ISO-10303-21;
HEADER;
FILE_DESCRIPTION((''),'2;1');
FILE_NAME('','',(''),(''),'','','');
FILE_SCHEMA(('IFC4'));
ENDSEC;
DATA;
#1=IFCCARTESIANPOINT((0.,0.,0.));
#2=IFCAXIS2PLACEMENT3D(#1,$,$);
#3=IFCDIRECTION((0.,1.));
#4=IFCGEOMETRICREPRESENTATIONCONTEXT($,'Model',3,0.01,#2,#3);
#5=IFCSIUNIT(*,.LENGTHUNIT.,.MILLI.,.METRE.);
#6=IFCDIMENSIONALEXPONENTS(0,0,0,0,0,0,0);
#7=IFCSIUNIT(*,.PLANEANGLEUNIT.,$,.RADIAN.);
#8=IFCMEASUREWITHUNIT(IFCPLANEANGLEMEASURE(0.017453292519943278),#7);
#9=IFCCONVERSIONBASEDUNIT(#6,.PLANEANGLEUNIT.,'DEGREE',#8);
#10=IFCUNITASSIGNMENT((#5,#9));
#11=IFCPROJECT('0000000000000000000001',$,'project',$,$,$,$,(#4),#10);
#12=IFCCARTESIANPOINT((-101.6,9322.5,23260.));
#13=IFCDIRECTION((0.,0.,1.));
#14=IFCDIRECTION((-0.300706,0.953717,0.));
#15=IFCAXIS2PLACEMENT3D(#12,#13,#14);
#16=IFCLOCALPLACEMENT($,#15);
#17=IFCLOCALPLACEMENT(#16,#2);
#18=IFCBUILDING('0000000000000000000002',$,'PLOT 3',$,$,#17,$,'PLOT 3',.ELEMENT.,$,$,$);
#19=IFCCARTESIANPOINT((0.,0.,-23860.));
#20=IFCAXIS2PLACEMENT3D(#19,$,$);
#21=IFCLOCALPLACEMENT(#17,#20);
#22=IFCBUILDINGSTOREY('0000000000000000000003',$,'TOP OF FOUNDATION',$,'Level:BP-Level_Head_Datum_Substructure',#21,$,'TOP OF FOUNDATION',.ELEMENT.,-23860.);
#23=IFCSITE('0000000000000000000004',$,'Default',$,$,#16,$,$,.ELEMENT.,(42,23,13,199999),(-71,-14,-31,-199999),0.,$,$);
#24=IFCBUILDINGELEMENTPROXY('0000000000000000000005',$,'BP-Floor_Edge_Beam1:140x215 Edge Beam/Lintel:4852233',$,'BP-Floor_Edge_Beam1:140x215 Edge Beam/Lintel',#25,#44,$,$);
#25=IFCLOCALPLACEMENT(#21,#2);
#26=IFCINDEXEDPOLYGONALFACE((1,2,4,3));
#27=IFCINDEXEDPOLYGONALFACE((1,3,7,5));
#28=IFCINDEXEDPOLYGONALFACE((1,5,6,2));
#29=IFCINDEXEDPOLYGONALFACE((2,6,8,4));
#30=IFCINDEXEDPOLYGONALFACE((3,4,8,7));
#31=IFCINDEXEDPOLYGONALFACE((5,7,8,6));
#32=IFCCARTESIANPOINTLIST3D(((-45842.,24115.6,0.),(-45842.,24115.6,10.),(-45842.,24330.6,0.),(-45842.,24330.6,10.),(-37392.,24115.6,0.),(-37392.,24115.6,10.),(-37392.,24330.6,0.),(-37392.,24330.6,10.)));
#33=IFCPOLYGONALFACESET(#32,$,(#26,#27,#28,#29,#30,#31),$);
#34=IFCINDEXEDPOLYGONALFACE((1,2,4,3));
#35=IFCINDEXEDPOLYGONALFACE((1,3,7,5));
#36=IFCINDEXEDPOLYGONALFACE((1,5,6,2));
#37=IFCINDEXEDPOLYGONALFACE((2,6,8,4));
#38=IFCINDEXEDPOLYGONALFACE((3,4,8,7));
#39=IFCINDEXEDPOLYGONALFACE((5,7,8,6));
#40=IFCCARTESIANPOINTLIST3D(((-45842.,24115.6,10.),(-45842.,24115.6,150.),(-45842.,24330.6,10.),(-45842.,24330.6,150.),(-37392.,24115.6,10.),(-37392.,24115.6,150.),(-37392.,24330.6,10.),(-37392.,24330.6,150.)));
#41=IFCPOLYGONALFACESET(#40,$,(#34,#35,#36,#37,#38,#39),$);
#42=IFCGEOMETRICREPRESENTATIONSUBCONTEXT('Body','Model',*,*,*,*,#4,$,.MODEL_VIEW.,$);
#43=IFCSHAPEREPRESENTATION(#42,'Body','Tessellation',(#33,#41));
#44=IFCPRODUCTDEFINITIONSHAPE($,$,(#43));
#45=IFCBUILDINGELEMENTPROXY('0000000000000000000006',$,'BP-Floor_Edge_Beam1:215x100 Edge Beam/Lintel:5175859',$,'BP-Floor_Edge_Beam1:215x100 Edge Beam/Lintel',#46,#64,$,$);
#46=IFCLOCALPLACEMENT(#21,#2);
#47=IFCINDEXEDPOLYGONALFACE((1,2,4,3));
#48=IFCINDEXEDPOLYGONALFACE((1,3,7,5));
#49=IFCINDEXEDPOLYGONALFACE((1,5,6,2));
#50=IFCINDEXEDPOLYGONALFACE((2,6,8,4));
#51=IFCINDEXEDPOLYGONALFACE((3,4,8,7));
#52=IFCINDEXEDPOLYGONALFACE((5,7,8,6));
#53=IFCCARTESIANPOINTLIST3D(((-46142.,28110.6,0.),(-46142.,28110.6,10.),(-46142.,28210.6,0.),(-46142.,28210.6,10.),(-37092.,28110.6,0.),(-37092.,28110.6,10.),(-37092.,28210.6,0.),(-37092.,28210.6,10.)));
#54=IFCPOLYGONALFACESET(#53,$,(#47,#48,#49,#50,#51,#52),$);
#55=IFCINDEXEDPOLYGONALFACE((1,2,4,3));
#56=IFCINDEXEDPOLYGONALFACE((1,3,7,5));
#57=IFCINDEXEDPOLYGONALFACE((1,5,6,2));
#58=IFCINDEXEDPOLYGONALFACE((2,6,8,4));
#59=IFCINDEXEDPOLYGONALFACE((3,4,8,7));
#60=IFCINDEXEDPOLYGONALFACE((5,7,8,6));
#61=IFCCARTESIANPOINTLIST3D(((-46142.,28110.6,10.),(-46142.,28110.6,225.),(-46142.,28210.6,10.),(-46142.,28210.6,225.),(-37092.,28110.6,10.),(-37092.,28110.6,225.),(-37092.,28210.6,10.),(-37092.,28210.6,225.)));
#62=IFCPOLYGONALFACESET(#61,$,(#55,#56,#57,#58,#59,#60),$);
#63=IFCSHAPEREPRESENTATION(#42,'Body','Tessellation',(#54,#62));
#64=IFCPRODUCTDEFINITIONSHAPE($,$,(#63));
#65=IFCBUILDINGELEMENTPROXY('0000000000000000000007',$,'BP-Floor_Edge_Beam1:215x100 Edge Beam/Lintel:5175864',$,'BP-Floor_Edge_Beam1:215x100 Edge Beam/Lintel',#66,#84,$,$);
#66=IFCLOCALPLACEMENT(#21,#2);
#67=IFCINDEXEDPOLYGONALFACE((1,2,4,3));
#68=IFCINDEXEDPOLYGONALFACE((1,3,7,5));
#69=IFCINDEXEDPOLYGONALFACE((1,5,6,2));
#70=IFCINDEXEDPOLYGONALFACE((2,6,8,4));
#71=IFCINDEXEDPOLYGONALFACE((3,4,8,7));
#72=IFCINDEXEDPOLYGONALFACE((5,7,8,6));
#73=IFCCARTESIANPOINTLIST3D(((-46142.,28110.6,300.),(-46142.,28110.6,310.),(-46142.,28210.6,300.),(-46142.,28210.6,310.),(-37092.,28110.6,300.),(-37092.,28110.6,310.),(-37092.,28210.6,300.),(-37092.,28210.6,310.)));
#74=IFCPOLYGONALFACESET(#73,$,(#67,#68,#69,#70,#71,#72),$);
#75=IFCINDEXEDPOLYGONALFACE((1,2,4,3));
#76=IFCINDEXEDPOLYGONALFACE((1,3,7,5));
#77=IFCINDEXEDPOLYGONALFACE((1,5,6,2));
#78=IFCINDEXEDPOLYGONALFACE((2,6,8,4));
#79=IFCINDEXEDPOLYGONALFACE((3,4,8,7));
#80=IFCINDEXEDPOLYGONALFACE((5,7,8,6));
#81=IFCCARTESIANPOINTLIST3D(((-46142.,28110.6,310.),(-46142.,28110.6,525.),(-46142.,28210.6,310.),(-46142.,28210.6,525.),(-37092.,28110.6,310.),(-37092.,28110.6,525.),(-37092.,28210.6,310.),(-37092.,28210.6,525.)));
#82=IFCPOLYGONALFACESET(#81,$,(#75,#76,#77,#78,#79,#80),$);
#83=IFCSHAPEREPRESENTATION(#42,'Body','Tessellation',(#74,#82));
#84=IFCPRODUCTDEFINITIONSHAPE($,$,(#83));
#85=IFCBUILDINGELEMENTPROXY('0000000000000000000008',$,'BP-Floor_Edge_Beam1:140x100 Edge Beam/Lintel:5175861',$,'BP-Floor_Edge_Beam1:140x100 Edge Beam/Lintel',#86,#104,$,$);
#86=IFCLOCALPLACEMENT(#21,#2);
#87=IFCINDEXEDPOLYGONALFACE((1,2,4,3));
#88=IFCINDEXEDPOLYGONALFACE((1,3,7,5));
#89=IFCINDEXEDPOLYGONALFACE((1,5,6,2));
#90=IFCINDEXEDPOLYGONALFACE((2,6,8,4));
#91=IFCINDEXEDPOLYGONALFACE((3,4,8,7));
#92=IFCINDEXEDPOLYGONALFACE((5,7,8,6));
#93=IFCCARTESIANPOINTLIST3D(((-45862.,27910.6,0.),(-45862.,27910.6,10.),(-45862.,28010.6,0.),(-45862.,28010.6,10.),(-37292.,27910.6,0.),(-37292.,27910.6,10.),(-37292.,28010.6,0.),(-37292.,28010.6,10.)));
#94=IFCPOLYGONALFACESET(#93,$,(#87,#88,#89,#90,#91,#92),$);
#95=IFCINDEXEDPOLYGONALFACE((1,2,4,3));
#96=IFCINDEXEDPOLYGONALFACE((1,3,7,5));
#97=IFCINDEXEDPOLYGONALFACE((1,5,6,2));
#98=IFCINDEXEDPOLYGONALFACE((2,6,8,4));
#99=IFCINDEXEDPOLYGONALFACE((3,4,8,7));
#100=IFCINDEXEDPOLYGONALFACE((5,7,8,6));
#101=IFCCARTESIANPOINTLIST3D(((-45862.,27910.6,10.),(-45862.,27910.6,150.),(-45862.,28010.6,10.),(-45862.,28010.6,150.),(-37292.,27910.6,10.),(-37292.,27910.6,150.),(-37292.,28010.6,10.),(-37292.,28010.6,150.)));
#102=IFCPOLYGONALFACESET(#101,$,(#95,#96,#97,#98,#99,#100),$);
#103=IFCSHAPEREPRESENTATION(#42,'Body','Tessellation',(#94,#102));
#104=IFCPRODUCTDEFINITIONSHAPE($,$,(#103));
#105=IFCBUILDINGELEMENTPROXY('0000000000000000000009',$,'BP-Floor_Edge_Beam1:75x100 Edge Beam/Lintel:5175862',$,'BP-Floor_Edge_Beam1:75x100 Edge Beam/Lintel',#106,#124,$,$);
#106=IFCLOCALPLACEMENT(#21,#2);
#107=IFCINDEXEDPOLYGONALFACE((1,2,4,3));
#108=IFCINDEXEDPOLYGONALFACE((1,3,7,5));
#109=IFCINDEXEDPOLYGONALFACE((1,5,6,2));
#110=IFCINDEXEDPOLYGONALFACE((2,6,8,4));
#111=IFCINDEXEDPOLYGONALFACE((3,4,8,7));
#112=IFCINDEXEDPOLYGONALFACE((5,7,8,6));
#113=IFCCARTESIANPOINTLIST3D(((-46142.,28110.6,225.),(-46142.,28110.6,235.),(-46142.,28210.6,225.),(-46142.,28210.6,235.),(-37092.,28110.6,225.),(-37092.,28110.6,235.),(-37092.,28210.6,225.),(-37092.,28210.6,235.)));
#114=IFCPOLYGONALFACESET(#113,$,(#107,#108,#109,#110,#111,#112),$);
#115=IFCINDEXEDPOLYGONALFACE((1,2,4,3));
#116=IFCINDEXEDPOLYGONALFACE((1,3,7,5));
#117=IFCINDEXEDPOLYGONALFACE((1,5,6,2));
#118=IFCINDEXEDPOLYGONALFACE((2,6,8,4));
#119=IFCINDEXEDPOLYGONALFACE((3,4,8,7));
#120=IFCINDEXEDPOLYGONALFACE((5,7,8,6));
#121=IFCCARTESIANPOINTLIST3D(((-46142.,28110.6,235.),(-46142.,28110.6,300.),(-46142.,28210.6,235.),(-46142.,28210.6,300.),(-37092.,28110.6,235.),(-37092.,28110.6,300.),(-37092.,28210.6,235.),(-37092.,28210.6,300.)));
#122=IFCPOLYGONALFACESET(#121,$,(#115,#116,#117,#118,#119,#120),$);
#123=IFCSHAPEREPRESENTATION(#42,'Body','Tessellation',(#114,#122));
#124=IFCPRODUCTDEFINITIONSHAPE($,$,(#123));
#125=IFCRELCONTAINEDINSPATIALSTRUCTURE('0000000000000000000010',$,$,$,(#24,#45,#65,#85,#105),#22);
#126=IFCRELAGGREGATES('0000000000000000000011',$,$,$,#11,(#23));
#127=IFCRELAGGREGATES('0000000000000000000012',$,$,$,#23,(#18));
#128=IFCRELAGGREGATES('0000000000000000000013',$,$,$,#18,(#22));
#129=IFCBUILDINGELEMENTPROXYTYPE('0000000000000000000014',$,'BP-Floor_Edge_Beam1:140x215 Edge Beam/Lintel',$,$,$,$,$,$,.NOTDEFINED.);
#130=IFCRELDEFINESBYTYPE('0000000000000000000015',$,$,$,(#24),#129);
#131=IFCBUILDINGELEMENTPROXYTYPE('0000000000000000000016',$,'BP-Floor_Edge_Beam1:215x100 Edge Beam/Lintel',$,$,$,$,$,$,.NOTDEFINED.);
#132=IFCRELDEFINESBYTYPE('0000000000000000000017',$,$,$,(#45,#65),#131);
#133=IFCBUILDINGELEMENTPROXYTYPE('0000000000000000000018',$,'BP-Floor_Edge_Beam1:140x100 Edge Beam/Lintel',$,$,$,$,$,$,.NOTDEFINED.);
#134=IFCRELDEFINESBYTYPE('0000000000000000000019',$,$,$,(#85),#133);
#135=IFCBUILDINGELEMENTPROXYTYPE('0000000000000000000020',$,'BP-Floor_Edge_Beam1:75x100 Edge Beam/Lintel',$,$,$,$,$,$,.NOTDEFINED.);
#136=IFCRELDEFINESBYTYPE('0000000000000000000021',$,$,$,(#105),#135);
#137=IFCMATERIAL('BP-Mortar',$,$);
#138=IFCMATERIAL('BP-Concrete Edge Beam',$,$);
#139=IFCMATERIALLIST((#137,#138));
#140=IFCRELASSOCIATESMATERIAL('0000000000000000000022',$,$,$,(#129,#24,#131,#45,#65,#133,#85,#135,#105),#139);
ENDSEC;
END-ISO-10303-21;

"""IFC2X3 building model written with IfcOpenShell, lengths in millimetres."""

from ifc_helpers import new_model, entity, si_unit, converted_unit, direction, frame, frame_2d, origin, origin_2d_with_axis, place, context, subcontext, project, spatial, rectangle, extrude, source, transform, mapped, material, material_list, type_object, type_shapes, element, save


model = new_model("IFC2X3")

# Units and contexts
model_context = context("Model", 3, precision=0.01, world=origin(), true_north=direction((0.0, 1.0)))
body_context = subcontext(model_context, "Body", "Model", "MODEL_VIEW")
ifc_project = project(units=[si_unit("LENGTHUNIT", "METRE", prefix="MILLI"), converted_unit("PLANEANGLEUNIT", "DEGREE", entity("IfcPlaneAngleMeasure", 0.017453292519943278), si_unit("PLANEANGLEUNIT", "RADIAN"), dimensions=[0, 0, 0, 0, 0, 0, 0])], contexts=[model_context])

# Site, building, storey
site_placement = place(None, frame((-101.6, 9322.5, 23260.0), z_axis=(0.0, 0.0, 1.0), x_axis=(-0.300706, 0.953717, 0.0)))
site = spatial("IfcSite", under=ifc_project, at=site_placement, Name="Default", CompositionType="ELEMENT", RefLatitude=(42, 23, 13, 199999), RefLongitude=(-71, -14, -31, -199999), RefElevation=0.0)
building_placement = place(site_placement, origin())
building = spatial("IfcBuilding", under=site, at=building_placement, Name="PLOT 3", LongName="PLOT 3", CompositionType="ELEMENT")
storey_placement = place(building_placement, frame((0.0, 0.0, -23860.0)))
storey = spatial("IfcBuildingStorey", under=building, at=storey_placement, Name="TOP OF FOUNDATION", ObjectType="Level:BP-Level_Head_Datum_Substructure", LongName="TOP OF FOUNDATION", CompositionType="ELEMENT", Elevation=-23860.0)

# Building element proxies
ifc_material_1 = material(Name="BP-Mortar")
ifc_material_2 = material(Name="BP-Concrete Edge Beam")
ifc_material_list = material_list([ifc_material_1, ifc_material_2])
building_element_proxy_type_1 = type_object("IfcBuildingElementProxyType", Name="BP-Floor_Edge_Beam1:140x215 Edge Beam/Lintel", PredefinedType="NOTDEFINED", material=ifc_material_list)
shared_shape_1 = source(origin(), body_context, "Body", "SweptSolid", [
    extrude(rectangle(XDim=215.0, YDim=8450.0, at=origin_2d_with_axis()), frame((0.0, 0.0, 0.0), z_axis=(0.0, 0.0, 1.0), x_axis=(0.0, 1.0, 0.0)), (0.0, 0.0, 1.0), 10.0),
    extrude(rectangle(XDim=215.0, YDim=8450.0, at=origin_2d_with_axis()), frame((0.0, 0.0, 10.0), z_axis=(0.0, 0.0, 1.0), x_axis=(0.0, 1.0, 0.0)), (0.0, 0.0, 1.0), 140.0),
])
type_shapes(building_element_proxy_type_1, [shared_shape_1])
proxy_1_placement = place(storey_placement, frame((-41617.0, 24223.1, 0.0), z_axis=(0.0, 0.0, 1.0), x_axis=(-1.0, 0.0, 0.0)))
element("IfcBuildingElementProxy", 1, at=proxy_1_placement, inside=storey, type_object=building_element_proxy_type_1, material=ifc_material_list, Name="BP-Floor_Edge_Beam1:140x215 Edge Beam/Lintel:4852233", ObjectType="BP-Floor_Edge_Beam1:140x215 Edge Beam/Lintel", context=body_context, shape_type="MappedRepresentation", body=[
    mapped(shared_shape_1, transform((0.0, 0.0, 0.0), scale=1.0)),
])
building_element_proxy_type_2 = type_object("IfcBuildingElementProxyType", Name="BP-Floor_Edge_Beam1:215x100 Edge Beam/Lintel", PredefinedType="NOTDEFINED", material=ifc_material_list)
shared_shape_2 = source(origin(), body_context, "Body", "SweptSolid", [
    extrude(rectangle(XDim=100.0, YDim=9050.0, at=frame_2d((0.0, 0.0), x_axis=(1.0, 0.0))), frame((0.0, 0.0, 0.0), z_axis=(0.0, 0.0, 1.0), x_axis=(0.0, 1.0, 0.0)), (0.0, 0.0, 1.0), 10.0),
    extrude(rectangle(XDim=100.0, YDim=9050.0, at=origin_2d_with_axis()), frame((0.0, 0.0, 10.0), z_axis=(0.0, 0.0, 1.0), x_axis=(0.0, 1.0, 0.0)), (0.0, 0.0, 1.0), 215.0),
])
type_shapes(building_element_proxy_type_2, [shared_shape_2])
for number, where, z_axis, x_axis, name in (
    (2, (-41617.0, 28160.6, 0.0), (0.0, 0.0, 1.0), (-1.0, 0.0, 0.0), "BP-Floor_Edge_Beam1:215x100 Edge Beam/Lintel:5175859"),
    (3, (-41617.0, 28160.6, 300.0), (0.0, 0.0, 1.0), (-1.0, 0.0, 0.0), "BP-Floor_Edge_Beam1:215x100 Edge Beam/Lintel:5175864"),
):
    element("IfcBuildingElementProxy", number, at=place(storey_placement, frame(where, z_axis=z_axis, x_axis=x_axis)), inside=storey, type_object=building_element_proxy_type_2, material=ifc_material_list, Name=name, ObjectType="BP-Floor_Edge_Beam1:215x100 Edge Beam/Lintel", context=body_context, shape_type="MappedRepresentation", body=[
        mapped(shared_shape_2, transform((0.0, 0.0, 0.0), scale=1.0)),
    ])
building_element_proxy_type_3 = type_object("IfcBuildingElementProxyType", Name="BP-Floor_Edge_Beam1:140x100 Edge Beam/Lintel", PredefinedType="NOTDEFINED", material=ifc_material_list)
shared_shape_3 = source(origin(), body_context, "Body", "SweptSolid", [
    extrude(rectangle(XDim=100.0, YDim=8570.0, at=frame_2d((0.0, 0.0), x_axis=(1.0, 0.0))), frame((0.0, 0.0, 0.0), z_axis=(0.0, 0.0, 1.0), x_axis=(0.0, 1.0, 0.0)), (0.0, 0.0, 1.0), 10.0),
    extrude(rectangle(XDim=100.0, YDim=8570.0, at=origin_2d_with_axis()), frame((0.0, 0.0, 10.0), z_axis=(0.0, 0.0, 1.0), x_axis=(0.0, 1.0, 0.0)), (0.0, 0.0, 1.0), 140.0),
])
type_shapes(building_element_proxy_type_3, [shared_shape_3])
proxy_2_placement = place(storey_placement, frame((-41577.0, 27960.6, 0.0), z_axis=(0.0, 0.0, 1.0), x_axis=(-1.0, 0.0, 0.0)))
element("IfcBuildingElementProxy", 4, at=proxy_2_placement, inside=storey, type_object=building_element_proxy_type_3, material=ifc_material_list, Name="BP-Floor_Edge_Beam1:140x100 Edge Beam/Lintel:5175861", ObjectType="BP-Floor_Edge_Beam1:140x100 Edge Beam/Lintel", context=body_context, shape_type="MappedRepresentation", body=[
    mapped(shared_shape_3, transform((0.0, 0.0, 0.0), scale=1.0)),
])
building_element_proxy_type_4 = type_object("IfcBuildingElementProxyType", Name="BP-Floor_Edge_Beam1:75x100 Edge Beam/Lintel", PredefinedType="NOTDEFINED", material=ifc_material_list)
shared_shape_4 = source(origin(), body_context, "Body", "SweptSolid", [
    extrude(rectangle(XDim=100.0, YDim=9050.0, at=frame_2d((0.0, 0.0), x_axis=(1.0, 0.0))), frame((0.0, 0.0, 0.0), z_axis=(0.0, 0.0, 1.0), x_axis=(0.0, 1.0, 0.0)), (0.0, 0.0, 1.0), 10.0),
    extrude(rectangle(XDim=100.0, YDim=9050.0, at=origin_2d_with_axis()), frame((0.0, 0.0, 10.0), z_axis=(0.0, 0.0, 1.0), x_axis=(0.0, 1.0, 0.0)), (0.0, 0.0, 1.0), 65.0),
])
type_shapes(building_element_proxy_type_4, [shared_shape_4])
proxy_3_placement = place(storey_placement, frame((-41617.0, 28160.6, 225.0), z_axis=(0.0, 0.0, 1.0), x_axis=(-1.0, 0.0, 0.0)))
element("IfcBuildingElementProxy", 5, at=proxy_3_placement, inside=storey, type_object=building_element_proxy_type_4, material=ifc_material_list, Name="BP-Floor_Edge_Beam1:75x100 Edge Beam/Lintel:5175862", ObjectType="BP-Floor_Edge_Beam1:75x100 Edge Beam/Lintel", context=body_context, shape_type="MappedRepresentation", body=[
    mapped(shared_shape_4, transform((0.0, 0.0, 0.0), scale=1.0)),
])

save(model, "model.ifc")
